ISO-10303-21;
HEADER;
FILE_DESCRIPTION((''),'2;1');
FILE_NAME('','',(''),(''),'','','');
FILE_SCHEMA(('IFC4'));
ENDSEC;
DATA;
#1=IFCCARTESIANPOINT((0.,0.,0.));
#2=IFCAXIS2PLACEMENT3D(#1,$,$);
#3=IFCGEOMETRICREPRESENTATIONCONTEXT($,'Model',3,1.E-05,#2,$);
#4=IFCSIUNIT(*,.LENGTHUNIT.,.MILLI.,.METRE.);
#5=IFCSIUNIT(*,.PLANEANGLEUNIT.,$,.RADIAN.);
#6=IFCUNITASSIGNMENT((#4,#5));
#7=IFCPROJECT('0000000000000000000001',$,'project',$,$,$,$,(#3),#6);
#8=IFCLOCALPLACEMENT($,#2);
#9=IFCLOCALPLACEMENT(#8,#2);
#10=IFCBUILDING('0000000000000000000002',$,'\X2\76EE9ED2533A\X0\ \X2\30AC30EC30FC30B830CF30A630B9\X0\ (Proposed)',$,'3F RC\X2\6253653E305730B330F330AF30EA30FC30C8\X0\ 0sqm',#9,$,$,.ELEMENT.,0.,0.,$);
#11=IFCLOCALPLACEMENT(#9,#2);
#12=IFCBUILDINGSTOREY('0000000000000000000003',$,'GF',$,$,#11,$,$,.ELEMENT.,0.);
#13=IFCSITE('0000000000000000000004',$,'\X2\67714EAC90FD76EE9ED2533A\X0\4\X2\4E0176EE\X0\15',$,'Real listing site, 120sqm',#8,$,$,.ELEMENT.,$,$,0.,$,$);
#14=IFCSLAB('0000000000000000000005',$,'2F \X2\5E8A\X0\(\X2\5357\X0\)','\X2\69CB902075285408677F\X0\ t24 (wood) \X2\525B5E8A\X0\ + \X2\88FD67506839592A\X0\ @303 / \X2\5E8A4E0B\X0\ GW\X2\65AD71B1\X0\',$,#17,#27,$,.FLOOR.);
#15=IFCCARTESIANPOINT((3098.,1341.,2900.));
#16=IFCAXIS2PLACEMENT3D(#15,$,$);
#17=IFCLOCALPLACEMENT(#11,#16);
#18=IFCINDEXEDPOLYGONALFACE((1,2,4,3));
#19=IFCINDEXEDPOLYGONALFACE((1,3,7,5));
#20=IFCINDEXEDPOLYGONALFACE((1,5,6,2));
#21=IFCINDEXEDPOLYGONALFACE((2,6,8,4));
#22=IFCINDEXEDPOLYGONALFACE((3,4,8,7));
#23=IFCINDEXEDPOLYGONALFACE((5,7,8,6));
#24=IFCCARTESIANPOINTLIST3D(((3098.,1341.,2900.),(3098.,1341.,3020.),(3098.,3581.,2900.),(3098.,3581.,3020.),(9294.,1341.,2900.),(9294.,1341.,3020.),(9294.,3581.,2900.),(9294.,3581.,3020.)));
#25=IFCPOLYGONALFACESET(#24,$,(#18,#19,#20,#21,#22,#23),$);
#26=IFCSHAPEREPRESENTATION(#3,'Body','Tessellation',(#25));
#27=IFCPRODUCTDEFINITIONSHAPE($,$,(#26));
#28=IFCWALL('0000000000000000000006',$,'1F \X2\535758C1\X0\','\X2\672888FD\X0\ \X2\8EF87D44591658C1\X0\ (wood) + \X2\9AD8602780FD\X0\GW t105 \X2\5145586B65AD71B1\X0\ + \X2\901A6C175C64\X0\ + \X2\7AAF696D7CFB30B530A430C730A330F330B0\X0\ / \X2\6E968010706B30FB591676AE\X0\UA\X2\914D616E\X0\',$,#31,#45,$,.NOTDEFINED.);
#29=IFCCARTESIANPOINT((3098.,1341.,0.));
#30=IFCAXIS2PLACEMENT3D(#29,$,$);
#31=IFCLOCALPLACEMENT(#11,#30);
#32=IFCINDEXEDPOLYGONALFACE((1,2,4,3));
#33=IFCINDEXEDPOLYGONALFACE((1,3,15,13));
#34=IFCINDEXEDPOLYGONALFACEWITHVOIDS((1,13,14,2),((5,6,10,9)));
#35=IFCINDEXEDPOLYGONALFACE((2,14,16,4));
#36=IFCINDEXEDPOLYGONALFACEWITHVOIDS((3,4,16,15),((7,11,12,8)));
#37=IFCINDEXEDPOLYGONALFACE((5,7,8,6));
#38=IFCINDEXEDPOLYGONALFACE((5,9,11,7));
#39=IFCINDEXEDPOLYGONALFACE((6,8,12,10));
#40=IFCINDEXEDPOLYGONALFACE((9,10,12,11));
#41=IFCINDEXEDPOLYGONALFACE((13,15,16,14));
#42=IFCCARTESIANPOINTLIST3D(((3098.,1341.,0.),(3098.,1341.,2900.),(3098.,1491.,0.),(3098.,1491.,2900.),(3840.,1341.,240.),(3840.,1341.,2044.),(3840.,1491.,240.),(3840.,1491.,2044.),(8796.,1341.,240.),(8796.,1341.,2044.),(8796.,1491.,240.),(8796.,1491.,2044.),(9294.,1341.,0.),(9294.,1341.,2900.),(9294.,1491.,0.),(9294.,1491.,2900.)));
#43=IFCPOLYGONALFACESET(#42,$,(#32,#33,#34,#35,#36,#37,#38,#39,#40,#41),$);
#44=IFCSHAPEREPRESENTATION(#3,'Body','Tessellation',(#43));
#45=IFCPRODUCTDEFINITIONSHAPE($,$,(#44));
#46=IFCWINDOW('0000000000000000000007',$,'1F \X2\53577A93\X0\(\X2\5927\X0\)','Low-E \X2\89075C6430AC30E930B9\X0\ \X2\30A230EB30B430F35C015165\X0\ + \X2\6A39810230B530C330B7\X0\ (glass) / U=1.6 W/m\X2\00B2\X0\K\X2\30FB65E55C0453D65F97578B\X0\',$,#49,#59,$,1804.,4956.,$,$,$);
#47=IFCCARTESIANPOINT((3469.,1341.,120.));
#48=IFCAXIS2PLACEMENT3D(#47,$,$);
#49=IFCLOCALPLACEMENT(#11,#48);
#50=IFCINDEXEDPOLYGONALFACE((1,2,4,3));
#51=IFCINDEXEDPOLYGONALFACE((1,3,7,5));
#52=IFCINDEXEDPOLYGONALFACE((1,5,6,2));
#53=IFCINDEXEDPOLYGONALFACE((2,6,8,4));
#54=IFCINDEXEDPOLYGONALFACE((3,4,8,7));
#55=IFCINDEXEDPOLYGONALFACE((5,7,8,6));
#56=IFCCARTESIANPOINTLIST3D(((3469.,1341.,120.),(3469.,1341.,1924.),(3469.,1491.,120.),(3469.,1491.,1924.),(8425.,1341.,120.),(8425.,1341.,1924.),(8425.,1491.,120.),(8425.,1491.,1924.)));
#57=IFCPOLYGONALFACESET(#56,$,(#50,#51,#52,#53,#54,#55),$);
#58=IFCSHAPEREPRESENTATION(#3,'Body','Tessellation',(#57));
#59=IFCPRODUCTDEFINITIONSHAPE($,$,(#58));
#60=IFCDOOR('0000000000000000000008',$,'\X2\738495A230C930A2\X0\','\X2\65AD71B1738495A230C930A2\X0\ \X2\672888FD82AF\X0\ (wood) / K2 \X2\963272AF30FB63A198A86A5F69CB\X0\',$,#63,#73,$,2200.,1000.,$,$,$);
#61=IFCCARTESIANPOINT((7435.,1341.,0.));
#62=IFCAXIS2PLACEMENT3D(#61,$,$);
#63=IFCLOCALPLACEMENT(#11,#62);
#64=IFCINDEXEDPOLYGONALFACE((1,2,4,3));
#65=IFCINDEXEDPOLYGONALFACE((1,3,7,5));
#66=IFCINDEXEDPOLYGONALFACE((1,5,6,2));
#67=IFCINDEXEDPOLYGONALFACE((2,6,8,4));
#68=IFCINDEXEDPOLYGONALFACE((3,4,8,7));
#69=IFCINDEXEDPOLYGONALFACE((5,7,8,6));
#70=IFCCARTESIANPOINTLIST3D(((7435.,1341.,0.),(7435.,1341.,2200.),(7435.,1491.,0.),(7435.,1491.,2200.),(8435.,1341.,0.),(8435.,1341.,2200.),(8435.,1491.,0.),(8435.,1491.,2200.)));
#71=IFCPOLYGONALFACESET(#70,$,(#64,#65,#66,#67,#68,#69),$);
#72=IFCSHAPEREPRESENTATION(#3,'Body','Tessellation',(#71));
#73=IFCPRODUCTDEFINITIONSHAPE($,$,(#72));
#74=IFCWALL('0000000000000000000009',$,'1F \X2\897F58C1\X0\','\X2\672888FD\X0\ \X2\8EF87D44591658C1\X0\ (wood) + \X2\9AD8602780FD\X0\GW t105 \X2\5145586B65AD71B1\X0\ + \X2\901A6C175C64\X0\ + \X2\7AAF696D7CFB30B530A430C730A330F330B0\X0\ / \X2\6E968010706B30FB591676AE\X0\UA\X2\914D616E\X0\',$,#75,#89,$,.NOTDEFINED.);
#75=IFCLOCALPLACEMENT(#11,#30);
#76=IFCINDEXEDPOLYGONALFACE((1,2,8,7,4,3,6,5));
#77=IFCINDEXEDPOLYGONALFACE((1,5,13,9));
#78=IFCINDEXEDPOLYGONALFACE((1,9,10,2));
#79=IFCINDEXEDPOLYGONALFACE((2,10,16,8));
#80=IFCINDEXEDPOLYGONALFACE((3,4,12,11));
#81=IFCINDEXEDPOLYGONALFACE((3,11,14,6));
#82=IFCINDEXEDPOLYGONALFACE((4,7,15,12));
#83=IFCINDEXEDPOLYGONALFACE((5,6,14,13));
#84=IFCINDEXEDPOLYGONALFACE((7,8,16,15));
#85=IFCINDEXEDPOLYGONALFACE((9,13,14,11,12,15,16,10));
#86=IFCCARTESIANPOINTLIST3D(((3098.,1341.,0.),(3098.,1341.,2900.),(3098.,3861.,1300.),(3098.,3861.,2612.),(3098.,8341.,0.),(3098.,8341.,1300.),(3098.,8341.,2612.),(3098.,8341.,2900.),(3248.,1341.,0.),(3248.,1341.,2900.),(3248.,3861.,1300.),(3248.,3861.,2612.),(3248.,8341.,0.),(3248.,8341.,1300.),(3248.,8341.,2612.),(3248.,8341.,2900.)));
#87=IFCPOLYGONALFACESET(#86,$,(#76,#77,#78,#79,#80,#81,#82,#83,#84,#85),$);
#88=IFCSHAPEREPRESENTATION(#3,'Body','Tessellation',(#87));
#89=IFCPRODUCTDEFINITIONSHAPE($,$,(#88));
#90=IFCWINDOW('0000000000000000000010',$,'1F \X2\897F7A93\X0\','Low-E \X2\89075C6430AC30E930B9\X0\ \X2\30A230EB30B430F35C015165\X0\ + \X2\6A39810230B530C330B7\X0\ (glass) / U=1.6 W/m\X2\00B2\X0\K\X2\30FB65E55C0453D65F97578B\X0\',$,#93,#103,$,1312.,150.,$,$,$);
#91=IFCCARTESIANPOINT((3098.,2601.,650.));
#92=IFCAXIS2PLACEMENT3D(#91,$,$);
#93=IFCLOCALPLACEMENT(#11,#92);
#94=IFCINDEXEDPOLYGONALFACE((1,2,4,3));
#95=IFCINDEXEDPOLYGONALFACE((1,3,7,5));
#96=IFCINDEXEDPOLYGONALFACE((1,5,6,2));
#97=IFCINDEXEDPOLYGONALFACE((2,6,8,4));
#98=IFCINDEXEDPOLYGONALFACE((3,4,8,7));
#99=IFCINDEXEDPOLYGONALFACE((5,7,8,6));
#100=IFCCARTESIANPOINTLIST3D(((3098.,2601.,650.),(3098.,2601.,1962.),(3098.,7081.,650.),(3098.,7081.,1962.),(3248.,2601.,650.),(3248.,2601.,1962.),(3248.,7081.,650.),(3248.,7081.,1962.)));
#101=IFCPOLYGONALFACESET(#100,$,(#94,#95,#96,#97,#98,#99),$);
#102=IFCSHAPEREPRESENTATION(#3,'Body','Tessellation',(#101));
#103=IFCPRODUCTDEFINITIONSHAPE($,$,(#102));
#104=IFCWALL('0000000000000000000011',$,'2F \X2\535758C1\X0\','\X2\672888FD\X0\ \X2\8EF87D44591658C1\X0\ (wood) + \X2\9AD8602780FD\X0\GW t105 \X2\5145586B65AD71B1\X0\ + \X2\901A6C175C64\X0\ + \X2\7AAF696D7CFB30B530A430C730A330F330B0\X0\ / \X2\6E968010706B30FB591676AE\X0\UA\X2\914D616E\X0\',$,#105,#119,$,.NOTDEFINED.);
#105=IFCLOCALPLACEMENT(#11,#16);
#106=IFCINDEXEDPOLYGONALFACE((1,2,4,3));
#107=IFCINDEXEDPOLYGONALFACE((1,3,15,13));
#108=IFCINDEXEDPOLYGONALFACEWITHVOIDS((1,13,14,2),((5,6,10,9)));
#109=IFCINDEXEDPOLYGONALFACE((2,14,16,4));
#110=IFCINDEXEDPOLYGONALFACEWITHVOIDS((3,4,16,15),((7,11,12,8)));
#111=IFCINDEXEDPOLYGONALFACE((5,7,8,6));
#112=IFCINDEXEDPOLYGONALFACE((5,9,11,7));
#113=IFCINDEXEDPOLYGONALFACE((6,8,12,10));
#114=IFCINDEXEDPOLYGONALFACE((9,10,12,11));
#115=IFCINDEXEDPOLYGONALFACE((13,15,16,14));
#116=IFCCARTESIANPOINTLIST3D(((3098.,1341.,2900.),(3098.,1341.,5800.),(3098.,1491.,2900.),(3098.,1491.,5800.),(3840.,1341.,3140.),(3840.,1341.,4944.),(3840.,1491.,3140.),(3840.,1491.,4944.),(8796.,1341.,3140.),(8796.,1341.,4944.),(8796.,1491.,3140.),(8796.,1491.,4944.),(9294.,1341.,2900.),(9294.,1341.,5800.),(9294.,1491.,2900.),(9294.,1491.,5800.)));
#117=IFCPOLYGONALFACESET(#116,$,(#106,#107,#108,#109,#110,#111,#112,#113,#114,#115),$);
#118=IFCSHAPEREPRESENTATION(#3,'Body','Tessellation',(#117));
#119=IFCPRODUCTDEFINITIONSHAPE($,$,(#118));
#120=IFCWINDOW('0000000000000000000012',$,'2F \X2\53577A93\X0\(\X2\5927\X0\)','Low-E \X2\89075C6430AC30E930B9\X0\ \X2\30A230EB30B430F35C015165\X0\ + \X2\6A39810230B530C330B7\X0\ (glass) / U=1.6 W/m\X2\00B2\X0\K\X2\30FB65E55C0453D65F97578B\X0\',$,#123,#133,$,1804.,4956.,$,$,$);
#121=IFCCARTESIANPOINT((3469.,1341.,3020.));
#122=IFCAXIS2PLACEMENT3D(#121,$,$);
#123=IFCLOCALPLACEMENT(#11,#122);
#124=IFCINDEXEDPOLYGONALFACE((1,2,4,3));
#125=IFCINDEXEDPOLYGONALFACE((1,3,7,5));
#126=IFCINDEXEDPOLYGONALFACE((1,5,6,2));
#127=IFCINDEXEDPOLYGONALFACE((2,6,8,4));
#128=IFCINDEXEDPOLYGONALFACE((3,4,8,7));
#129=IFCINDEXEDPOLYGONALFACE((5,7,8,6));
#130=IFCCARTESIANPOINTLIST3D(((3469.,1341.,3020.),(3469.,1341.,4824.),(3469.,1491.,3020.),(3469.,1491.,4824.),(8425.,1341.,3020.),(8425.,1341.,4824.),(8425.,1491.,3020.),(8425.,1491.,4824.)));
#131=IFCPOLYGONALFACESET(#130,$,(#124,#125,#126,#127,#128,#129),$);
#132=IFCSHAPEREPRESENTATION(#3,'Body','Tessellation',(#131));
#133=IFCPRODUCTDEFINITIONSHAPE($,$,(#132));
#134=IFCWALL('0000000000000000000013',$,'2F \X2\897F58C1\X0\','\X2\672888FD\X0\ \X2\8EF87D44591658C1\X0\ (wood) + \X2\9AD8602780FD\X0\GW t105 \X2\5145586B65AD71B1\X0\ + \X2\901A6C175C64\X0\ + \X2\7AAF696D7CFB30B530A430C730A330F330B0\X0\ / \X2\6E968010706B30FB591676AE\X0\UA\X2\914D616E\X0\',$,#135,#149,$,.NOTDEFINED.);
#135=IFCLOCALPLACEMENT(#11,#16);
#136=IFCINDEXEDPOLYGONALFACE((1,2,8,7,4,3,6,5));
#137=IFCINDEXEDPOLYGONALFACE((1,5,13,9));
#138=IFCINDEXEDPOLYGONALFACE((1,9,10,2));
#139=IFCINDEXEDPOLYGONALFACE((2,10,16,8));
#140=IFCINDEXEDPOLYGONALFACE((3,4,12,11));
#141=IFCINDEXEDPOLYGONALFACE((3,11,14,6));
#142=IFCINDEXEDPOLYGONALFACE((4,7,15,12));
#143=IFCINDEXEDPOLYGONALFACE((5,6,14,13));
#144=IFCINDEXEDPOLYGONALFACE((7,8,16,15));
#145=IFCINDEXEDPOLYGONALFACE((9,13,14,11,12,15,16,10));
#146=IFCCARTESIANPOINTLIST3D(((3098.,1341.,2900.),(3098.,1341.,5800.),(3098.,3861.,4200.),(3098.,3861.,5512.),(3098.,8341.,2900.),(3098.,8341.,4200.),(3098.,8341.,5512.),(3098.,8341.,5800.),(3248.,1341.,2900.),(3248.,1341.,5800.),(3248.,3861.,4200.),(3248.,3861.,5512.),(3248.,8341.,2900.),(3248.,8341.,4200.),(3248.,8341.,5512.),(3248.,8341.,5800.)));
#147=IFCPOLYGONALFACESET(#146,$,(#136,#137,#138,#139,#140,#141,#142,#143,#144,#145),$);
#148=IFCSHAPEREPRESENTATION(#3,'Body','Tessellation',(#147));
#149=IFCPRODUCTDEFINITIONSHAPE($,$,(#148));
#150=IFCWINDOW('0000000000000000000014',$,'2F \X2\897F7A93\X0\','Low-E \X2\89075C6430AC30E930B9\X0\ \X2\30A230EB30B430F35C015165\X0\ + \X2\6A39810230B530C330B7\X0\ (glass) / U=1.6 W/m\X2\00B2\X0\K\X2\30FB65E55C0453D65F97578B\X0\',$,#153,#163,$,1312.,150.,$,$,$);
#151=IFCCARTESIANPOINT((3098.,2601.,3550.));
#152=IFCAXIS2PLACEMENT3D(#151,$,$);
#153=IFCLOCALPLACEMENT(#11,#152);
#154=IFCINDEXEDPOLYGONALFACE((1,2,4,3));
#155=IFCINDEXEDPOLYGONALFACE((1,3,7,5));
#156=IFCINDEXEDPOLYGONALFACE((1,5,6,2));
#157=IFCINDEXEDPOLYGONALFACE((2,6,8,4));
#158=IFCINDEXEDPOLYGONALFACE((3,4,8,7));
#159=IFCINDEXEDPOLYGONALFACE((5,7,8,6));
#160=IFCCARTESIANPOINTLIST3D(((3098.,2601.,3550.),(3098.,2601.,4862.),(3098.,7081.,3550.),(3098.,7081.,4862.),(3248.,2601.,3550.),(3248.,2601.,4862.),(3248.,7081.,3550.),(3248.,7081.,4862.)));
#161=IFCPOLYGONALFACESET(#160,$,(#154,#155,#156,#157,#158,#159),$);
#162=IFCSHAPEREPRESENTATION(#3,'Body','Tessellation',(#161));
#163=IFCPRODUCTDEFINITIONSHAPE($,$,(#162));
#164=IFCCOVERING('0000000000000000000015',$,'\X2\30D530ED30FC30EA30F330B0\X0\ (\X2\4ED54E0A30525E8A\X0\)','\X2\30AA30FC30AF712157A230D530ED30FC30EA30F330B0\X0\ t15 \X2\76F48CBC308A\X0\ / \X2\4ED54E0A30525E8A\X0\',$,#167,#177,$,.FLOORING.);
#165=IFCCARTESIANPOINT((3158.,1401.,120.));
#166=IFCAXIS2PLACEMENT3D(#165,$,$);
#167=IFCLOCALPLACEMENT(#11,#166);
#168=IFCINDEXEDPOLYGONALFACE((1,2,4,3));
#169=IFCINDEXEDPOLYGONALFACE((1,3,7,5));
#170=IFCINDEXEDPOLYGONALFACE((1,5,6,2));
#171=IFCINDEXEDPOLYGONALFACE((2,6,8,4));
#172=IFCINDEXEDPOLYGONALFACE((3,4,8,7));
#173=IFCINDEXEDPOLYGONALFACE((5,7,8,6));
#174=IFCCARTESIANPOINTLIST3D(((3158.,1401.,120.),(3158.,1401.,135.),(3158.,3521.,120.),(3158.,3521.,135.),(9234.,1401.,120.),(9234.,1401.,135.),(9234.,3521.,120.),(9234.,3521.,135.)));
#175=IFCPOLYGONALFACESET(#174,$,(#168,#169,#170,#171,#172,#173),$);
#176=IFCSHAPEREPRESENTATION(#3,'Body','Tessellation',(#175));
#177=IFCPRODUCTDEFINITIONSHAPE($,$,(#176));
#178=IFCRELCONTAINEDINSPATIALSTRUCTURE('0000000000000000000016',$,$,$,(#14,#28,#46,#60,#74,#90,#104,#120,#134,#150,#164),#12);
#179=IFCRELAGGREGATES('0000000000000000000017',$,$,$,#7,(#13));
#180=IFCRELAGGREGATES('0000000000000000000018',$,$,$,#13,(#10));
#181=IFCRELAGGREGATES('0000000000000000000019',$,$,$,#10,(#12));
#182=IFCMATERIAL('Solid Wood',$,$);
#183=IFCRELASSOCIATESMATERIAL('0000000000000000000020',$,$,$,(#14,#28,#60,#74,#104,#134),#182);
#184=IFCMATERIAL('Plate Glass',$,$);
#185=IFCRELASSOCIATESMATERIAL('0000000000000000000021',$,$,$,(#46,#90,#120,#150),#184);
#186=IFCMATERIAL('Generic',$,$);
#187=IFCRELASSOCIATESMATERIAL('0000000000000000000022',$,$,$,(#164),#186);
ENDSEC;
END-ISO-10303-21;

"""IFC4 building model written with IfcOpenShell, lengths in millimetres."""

from ifc_helpers import new_model, si_unit, frame, frame_2d, origin, place, context, project, spatial, rectangle, extrude, material, element, fill, save


model = new_model("IFC4")

# Units and contexts
model_context = context("Model", 3, precision=1e-05, world=origin())
ifc_project = project(units=[si_unit("LENGTHUNIT", "METRE", prefix="MILLI"), si_unit("PLANEANGLEUNIT", "RADIAN")], contexts=[model_context])

# Site, building, storey
site_placement = place(None, origin())
site = spatial("IfcSite", under=ifc_project, at=site_placement, Name="東京都目黒区4丁目15", ObjectType="Real listing site, 120sqm", CompositionType="ELEMENT", RefElevation=0.0)
building_placement = place(site_placement, origin())
building = spatial("IfcBuilding", under=site, at=building_placement, Name="目黒区 ガレージハウス (Proposed)", ObjectType="3F RC打放しコンクリート 0sqm", CompositionType="ELEMENT", ElevationOfRefHeight=0.0, ElevationOfTerrain=0.0)
storey_placement = place(building_placement, origin())
storey = spatial("IfcBuildingStorey", under=building, at=storey_placement, Name="GF", CompositionType="ELEMENT", Elevation=0.0)

# Slab
ifc_material_1 = material(Name="Solid Wood")
slab_1_placement = place(storey_placement, frame((3098.0, 1341.0, 2900.0)))
element("IfcSlab", 1, at=slab_1_placement, inside=storey, material=ifc_material_1, Name="2F 床(南)", Description="構造用合板 t24 (wood) 剛床 + 製材根太 @303 / 床下 GW断熱", PredefinedType="FLOOR", context=model_context, shape_type="SweptSolid", body=[
    extrude(rectangle(XDim=6196.0, YDim=2240.0, at=frame_2d((3098.0, 1120.0))), frame((3098.0, 1341.0, 2900.0)), (0.0, 0.0, 1.0), 120.0),
])

# Wall, openings, window, door
wall_1_placement = place(storey_placement, frame((3098.0, 1341.0, 0.0)))
wall_1 = element("IfcWall", 2, at=wall_1_placement, inside=storey, material=ifc_material_1, Name="1F 南壁", Description="木製 軸組外壁 (wood) + 高性能GW t105 充填断熱 + 通気層 + 窯業系サイディング / 準耐火・外皮UA配慮", PredefinedType="NOTDEFINED", context=model_context, shape_type="SweptSolid", body=[
    extrude(rectangle(XDim=6196.0, YDim=150.0, at=frame_2d((3098.0, 75.0))), frame((3098.0, 1341.0, 0.0)), (0.0, 0.0, 1.0), 2900.0),
])
opening_1_placement = place(storey_placement, frame((3469.0, 1341.0, 120.0)))
opening_1 = element("IfcOpeningElement", 3, at=opening_1_placement, cuts=wall_1, PredefinedType="NOTDEFINED", context=model_context, shape_type="SweptSolid", body=[
    extrude(rectangle(XDim=4956.0, YDim=150.0, at=frame_2d((2478.0, 75.0))), frame((3469.0, 1341.0, 120.0)), (0.0, 0.0, 1.0), 1804.0),
])
opening_2_placement = place(storey_placement, frame((7435.0, 1341.0, 0.0)))
opening_2 = element("IfcOpeningElement", 4, at=opening_2_placement, cuts=wall_1, PredefinedType="NOTDEFINED", context=model_context, shape_type="SweptSolid", body=[
    extrude(rectangle(XDim=1000.0, YDim=150.0, at=frame_2d((500.0, 75.0))), frame((7435.0, 1341.0, 0.0)), (0.0, 0.0, 1.0), 2200.0),
])
ifc_material_2 = material(Name="Plate Glass")
window_1_placement = place(storey_placement, frame((3469.0, 1341.0, 120.0)))
window_1 = element("IfcWindow", 5, at=window_1_placement, inside=storey, material=ifc_material_2, Name="1F 南窓(大)", Description="Low-E 複層ガラス アルゴン封入 + 樹脂サッシ (glass) / U=1.6 W/m²K・日射取得型", OverallHeight=1804.0, OverallWidth=4956.0, context=model_context, shape_type="SweptSolid", body=[
    extrude(rectangle(XDim=4956.0, YDim=150.0, at=frame_2d((2478.0, 75.0))), frame((3469.0, 1341.0, 120.0)), (0.0, 0.0, 1.0), 1804.0),
])
fill(opening_1, window_1)
door_placement = place(storey_placement, frame((7435.0, 1341.0, 0.0)))
door = element("IfcDoor", 6, at=door_placement, inside=storey, material=ifc_material_1, Name="玄関ドア", Description="断熱玄関ドア 木製芯 (wood) / K2 防犯・採風機構", OverallHeight=2200.0, OverallWidth=1000.0, context=model_context, shape_type="SweptSolid", body=[
    extrude(rectangle(XDim=1000.0, YDim=150.0, at=frame_2d((500.0, 75.0))), frame((7435.0, 1341.0, 0.0)), (0.0, 0.0, 1.0), 2200.0),
])
fill(opening_2, door)

# Walls, openings, windows
wall_2_placement = place(storey_placement, frame((3098.0, 1341.0, 0.0)))
wall_2 = element("IfcWall", 7, at=wall_2_placement, inside=storey, material=ifc_material_1, Name="1F 西壁", Description="木製 軸組外壁 (wood) + 高性能GW t105 充填断熱 + 通気層 + 窯業系サイディング / 準耐火・外皮UA配慮", PredefinedType="NOTDEFINED", context=model_context, shape_type="SweptSolid", body=[
    extrude(rectangle(XDim=150.0, YDim=7000.0, at=frame_2d((75.0, 3500.0))), frame((3098.0, 1341.0, 0.0)), (0.0, 0.0, 1.0), 2900.0),
])
opening_3_placement = place(storey_placement, frame((3098.0, 2601.0, 650.0)))
opening_3 = element("IfcOpeningElement", 8, at=opening_3_placement, cuts=wall_2, PredefinedType="NOTDEFINED", context=model_context, shape_type="SweptSolid", body=[
    extrude(rectangle(XDim=150.0, YDim=4480.0, at=frame_2d((75.0, 2240.0))), frame((3098.0, 2601.0, 650.0)), (0.0, 0.0, 1.0), 1312.0),
])
window_2_placement = place(storey_placement, frame((3098.0, 2601.0, 650.0)))
window_2 = element("IfcWindow", 9, at=window_2_placement, inside=storey, material=ifc_material_2, Name="1F 西窓", Description="Low-E 複層ガラス アルゴン封入 + 樹脂サッシ (glass) / U=1.6 W/m²K・日射取得型", OverallHeight=1312.0, OverallWidth=150.0, context=model_context, shape_type="SweptSolid", body=[
    extrude(rectangle(XDim=150.0, YDim=4480.0, at=frame_2d((75.0, 2240.0))), frame((3098.0, 2601.0, 650.0)), (0.0, 0.0, 1.0), 1312.0),
])
fill(opening_3, window_2)
wall_3_placement = place(storey_placement, frame((3098.0, 1341.0, 2900.0)))
wall_3 = element("IfcWall", 10, at=wall_3_placement, inside=storey, material=ifc_material_1, Name="2F 南壁", Description="木製 軸組外壁 (wood) + 高性能GW t105 充填断熱 + 通気層 + 窯業系サイディング / 準耐火・外皮UA配慮", PredefinedType="NOTDEFINED", context=model_context, shape_type="SweptSolid", body=[
    extrude(rectangle(XDim=6196.0, YDim=150.0, at=frame_2d((3098.0, 75.0))), frame((3098.0, 1341.0, 2900.0)), (0.0, 0.0, 1.0), 2900.0),
])
opening_4_placement = place(storey_placement, frame((3469.0, 1341.0, 3020.0)))
opening_4 = element("IfcOpeningElement", 11, at=opening_4_placement, cuts=wall_3, PredefinedType="NOTDEFINED", context=model_context, shape_type="SweptSolid", body=[
    extrude(rectangle(XDim=4956.0, YDim=150.0, at=frame_2d((2478.0, 75.0))), frame((3469.0, 1341.0, 3020.0)), (0.0, 0.0, 1.0), 1804.0),
])
window_3_placement = place(storey_placement, frame((3469.0, 1341.0, 3020.0)))
window_3 = element("IfcWindow", 12, at=window_3_placement, inside=storey, material=ifc_material_2, Name="2F 南窓(大)", Description="Low-E 複層ガラス アルゴン封入 + 樹脂サッシ (glass) / U=1.6 W/m²K・日射取得型", OverallHeight=1804.0, OverallWidth=4956.0, context=model_context, shape_type="SweptSolid", body=[
    extrude(rectangle(XDim=4956.0, YDim=150.0, at=frame_2d((2478.0, 75.0))), frame((3469.0, 1341.0, 3020.0)), (0.0, 0.0, 1.0), 1804.0),
])
fill(opening_4, window_3)
wall_4_placement = place(storey_placement, frame((3098.0, 1341.0, 2900.0)))
wall_4 = element("IfcWall", 13, at=wall_4_placement, inside=storey, material=ifc_material_1, Name="2F 西壁", Description="木製 軸組外壁 (wood) + 高性能GW t105 充填断熱 + 通気層 + 窯業系サイディング / 準耐火・外皮UA配慮", PredefinedType="NOTDEFINED", context=model_context, shape_type="SweptSolid", body=[
    extrude(rectangle(XDim=150.0, YDim=7000.0, at=frame_2d((75.0, 3500.0))), frame((3098.0, 1341.0, 2900.0)), (0.0, 0.0, 1.0), 2900.0),
])
opening_5_placement = place(storey_placement, frame((3098.0, 2601.0, 3550.0)))
opening_5 = element("IfcOpeningElement", 14, at=opening_5_placement, cuts=wall_4, PredefinedType="NOTDEFINED", context=model_context, shape_type="SweptSolid", body=[
    extrude(rectangle(XDim=150.0, YDim=4480.0, at=frame_2d((75.0, 2240.0))), frame((3098.0, 2601.0, 3550.0)), (0.0, 0.0, 1.0), 1312.0),
])
window_4_placement = place(storey_placement, frame((3098.0, 2601.0, 3550.0)))
window_4 = element("IfcWindow", 15, at=window_4_placement, inside=storey, material=ifc_material_2, Name="2F 西窓", Description="Low-E 複層ガラス アルゴン封入 + 樹脂サッシ (glass) / U=1.6 W/m²K・日射取得型", OverallHeight=1312.0, OverallWidth=150.0, context=model_context, shape_type="SweptSolid", body=[
    extrude(rectangle(XDim=150.0, YDim=4480.0, at=frame_2d((75.0, 2240.0))), frame((3098.0, 2601.0, 3550.0)), (0.0, 0.0, 1.0), 1312.0),
])
fill(opening_5, window_4)

# Covering
ifc_material_3 = material(Name="Generic")
covering_placement = place(storey_placement, frame((3158.0, 1401.0, 120.0)))
element("IfcCovering", 16, at=covering_placement, inside=storey, material=ifc_material_3, Name="フローリング (仕上げ床)", Description="オーク無垢フローリング t15 直貼り / 仕上げ床", PredefinedType="FLOORING", context=model_context, shape_type="SweptSolid", body=[
    extrude(rectangle(XDim=6076.0, YDim=2120.0, at=frame_2d((3038.0, 1060.0))), frame((3158.0, 1401.0, 120.0)), (0.0, 0.0, 1.0), 15.0),
])

save(model, "model.ifc")
